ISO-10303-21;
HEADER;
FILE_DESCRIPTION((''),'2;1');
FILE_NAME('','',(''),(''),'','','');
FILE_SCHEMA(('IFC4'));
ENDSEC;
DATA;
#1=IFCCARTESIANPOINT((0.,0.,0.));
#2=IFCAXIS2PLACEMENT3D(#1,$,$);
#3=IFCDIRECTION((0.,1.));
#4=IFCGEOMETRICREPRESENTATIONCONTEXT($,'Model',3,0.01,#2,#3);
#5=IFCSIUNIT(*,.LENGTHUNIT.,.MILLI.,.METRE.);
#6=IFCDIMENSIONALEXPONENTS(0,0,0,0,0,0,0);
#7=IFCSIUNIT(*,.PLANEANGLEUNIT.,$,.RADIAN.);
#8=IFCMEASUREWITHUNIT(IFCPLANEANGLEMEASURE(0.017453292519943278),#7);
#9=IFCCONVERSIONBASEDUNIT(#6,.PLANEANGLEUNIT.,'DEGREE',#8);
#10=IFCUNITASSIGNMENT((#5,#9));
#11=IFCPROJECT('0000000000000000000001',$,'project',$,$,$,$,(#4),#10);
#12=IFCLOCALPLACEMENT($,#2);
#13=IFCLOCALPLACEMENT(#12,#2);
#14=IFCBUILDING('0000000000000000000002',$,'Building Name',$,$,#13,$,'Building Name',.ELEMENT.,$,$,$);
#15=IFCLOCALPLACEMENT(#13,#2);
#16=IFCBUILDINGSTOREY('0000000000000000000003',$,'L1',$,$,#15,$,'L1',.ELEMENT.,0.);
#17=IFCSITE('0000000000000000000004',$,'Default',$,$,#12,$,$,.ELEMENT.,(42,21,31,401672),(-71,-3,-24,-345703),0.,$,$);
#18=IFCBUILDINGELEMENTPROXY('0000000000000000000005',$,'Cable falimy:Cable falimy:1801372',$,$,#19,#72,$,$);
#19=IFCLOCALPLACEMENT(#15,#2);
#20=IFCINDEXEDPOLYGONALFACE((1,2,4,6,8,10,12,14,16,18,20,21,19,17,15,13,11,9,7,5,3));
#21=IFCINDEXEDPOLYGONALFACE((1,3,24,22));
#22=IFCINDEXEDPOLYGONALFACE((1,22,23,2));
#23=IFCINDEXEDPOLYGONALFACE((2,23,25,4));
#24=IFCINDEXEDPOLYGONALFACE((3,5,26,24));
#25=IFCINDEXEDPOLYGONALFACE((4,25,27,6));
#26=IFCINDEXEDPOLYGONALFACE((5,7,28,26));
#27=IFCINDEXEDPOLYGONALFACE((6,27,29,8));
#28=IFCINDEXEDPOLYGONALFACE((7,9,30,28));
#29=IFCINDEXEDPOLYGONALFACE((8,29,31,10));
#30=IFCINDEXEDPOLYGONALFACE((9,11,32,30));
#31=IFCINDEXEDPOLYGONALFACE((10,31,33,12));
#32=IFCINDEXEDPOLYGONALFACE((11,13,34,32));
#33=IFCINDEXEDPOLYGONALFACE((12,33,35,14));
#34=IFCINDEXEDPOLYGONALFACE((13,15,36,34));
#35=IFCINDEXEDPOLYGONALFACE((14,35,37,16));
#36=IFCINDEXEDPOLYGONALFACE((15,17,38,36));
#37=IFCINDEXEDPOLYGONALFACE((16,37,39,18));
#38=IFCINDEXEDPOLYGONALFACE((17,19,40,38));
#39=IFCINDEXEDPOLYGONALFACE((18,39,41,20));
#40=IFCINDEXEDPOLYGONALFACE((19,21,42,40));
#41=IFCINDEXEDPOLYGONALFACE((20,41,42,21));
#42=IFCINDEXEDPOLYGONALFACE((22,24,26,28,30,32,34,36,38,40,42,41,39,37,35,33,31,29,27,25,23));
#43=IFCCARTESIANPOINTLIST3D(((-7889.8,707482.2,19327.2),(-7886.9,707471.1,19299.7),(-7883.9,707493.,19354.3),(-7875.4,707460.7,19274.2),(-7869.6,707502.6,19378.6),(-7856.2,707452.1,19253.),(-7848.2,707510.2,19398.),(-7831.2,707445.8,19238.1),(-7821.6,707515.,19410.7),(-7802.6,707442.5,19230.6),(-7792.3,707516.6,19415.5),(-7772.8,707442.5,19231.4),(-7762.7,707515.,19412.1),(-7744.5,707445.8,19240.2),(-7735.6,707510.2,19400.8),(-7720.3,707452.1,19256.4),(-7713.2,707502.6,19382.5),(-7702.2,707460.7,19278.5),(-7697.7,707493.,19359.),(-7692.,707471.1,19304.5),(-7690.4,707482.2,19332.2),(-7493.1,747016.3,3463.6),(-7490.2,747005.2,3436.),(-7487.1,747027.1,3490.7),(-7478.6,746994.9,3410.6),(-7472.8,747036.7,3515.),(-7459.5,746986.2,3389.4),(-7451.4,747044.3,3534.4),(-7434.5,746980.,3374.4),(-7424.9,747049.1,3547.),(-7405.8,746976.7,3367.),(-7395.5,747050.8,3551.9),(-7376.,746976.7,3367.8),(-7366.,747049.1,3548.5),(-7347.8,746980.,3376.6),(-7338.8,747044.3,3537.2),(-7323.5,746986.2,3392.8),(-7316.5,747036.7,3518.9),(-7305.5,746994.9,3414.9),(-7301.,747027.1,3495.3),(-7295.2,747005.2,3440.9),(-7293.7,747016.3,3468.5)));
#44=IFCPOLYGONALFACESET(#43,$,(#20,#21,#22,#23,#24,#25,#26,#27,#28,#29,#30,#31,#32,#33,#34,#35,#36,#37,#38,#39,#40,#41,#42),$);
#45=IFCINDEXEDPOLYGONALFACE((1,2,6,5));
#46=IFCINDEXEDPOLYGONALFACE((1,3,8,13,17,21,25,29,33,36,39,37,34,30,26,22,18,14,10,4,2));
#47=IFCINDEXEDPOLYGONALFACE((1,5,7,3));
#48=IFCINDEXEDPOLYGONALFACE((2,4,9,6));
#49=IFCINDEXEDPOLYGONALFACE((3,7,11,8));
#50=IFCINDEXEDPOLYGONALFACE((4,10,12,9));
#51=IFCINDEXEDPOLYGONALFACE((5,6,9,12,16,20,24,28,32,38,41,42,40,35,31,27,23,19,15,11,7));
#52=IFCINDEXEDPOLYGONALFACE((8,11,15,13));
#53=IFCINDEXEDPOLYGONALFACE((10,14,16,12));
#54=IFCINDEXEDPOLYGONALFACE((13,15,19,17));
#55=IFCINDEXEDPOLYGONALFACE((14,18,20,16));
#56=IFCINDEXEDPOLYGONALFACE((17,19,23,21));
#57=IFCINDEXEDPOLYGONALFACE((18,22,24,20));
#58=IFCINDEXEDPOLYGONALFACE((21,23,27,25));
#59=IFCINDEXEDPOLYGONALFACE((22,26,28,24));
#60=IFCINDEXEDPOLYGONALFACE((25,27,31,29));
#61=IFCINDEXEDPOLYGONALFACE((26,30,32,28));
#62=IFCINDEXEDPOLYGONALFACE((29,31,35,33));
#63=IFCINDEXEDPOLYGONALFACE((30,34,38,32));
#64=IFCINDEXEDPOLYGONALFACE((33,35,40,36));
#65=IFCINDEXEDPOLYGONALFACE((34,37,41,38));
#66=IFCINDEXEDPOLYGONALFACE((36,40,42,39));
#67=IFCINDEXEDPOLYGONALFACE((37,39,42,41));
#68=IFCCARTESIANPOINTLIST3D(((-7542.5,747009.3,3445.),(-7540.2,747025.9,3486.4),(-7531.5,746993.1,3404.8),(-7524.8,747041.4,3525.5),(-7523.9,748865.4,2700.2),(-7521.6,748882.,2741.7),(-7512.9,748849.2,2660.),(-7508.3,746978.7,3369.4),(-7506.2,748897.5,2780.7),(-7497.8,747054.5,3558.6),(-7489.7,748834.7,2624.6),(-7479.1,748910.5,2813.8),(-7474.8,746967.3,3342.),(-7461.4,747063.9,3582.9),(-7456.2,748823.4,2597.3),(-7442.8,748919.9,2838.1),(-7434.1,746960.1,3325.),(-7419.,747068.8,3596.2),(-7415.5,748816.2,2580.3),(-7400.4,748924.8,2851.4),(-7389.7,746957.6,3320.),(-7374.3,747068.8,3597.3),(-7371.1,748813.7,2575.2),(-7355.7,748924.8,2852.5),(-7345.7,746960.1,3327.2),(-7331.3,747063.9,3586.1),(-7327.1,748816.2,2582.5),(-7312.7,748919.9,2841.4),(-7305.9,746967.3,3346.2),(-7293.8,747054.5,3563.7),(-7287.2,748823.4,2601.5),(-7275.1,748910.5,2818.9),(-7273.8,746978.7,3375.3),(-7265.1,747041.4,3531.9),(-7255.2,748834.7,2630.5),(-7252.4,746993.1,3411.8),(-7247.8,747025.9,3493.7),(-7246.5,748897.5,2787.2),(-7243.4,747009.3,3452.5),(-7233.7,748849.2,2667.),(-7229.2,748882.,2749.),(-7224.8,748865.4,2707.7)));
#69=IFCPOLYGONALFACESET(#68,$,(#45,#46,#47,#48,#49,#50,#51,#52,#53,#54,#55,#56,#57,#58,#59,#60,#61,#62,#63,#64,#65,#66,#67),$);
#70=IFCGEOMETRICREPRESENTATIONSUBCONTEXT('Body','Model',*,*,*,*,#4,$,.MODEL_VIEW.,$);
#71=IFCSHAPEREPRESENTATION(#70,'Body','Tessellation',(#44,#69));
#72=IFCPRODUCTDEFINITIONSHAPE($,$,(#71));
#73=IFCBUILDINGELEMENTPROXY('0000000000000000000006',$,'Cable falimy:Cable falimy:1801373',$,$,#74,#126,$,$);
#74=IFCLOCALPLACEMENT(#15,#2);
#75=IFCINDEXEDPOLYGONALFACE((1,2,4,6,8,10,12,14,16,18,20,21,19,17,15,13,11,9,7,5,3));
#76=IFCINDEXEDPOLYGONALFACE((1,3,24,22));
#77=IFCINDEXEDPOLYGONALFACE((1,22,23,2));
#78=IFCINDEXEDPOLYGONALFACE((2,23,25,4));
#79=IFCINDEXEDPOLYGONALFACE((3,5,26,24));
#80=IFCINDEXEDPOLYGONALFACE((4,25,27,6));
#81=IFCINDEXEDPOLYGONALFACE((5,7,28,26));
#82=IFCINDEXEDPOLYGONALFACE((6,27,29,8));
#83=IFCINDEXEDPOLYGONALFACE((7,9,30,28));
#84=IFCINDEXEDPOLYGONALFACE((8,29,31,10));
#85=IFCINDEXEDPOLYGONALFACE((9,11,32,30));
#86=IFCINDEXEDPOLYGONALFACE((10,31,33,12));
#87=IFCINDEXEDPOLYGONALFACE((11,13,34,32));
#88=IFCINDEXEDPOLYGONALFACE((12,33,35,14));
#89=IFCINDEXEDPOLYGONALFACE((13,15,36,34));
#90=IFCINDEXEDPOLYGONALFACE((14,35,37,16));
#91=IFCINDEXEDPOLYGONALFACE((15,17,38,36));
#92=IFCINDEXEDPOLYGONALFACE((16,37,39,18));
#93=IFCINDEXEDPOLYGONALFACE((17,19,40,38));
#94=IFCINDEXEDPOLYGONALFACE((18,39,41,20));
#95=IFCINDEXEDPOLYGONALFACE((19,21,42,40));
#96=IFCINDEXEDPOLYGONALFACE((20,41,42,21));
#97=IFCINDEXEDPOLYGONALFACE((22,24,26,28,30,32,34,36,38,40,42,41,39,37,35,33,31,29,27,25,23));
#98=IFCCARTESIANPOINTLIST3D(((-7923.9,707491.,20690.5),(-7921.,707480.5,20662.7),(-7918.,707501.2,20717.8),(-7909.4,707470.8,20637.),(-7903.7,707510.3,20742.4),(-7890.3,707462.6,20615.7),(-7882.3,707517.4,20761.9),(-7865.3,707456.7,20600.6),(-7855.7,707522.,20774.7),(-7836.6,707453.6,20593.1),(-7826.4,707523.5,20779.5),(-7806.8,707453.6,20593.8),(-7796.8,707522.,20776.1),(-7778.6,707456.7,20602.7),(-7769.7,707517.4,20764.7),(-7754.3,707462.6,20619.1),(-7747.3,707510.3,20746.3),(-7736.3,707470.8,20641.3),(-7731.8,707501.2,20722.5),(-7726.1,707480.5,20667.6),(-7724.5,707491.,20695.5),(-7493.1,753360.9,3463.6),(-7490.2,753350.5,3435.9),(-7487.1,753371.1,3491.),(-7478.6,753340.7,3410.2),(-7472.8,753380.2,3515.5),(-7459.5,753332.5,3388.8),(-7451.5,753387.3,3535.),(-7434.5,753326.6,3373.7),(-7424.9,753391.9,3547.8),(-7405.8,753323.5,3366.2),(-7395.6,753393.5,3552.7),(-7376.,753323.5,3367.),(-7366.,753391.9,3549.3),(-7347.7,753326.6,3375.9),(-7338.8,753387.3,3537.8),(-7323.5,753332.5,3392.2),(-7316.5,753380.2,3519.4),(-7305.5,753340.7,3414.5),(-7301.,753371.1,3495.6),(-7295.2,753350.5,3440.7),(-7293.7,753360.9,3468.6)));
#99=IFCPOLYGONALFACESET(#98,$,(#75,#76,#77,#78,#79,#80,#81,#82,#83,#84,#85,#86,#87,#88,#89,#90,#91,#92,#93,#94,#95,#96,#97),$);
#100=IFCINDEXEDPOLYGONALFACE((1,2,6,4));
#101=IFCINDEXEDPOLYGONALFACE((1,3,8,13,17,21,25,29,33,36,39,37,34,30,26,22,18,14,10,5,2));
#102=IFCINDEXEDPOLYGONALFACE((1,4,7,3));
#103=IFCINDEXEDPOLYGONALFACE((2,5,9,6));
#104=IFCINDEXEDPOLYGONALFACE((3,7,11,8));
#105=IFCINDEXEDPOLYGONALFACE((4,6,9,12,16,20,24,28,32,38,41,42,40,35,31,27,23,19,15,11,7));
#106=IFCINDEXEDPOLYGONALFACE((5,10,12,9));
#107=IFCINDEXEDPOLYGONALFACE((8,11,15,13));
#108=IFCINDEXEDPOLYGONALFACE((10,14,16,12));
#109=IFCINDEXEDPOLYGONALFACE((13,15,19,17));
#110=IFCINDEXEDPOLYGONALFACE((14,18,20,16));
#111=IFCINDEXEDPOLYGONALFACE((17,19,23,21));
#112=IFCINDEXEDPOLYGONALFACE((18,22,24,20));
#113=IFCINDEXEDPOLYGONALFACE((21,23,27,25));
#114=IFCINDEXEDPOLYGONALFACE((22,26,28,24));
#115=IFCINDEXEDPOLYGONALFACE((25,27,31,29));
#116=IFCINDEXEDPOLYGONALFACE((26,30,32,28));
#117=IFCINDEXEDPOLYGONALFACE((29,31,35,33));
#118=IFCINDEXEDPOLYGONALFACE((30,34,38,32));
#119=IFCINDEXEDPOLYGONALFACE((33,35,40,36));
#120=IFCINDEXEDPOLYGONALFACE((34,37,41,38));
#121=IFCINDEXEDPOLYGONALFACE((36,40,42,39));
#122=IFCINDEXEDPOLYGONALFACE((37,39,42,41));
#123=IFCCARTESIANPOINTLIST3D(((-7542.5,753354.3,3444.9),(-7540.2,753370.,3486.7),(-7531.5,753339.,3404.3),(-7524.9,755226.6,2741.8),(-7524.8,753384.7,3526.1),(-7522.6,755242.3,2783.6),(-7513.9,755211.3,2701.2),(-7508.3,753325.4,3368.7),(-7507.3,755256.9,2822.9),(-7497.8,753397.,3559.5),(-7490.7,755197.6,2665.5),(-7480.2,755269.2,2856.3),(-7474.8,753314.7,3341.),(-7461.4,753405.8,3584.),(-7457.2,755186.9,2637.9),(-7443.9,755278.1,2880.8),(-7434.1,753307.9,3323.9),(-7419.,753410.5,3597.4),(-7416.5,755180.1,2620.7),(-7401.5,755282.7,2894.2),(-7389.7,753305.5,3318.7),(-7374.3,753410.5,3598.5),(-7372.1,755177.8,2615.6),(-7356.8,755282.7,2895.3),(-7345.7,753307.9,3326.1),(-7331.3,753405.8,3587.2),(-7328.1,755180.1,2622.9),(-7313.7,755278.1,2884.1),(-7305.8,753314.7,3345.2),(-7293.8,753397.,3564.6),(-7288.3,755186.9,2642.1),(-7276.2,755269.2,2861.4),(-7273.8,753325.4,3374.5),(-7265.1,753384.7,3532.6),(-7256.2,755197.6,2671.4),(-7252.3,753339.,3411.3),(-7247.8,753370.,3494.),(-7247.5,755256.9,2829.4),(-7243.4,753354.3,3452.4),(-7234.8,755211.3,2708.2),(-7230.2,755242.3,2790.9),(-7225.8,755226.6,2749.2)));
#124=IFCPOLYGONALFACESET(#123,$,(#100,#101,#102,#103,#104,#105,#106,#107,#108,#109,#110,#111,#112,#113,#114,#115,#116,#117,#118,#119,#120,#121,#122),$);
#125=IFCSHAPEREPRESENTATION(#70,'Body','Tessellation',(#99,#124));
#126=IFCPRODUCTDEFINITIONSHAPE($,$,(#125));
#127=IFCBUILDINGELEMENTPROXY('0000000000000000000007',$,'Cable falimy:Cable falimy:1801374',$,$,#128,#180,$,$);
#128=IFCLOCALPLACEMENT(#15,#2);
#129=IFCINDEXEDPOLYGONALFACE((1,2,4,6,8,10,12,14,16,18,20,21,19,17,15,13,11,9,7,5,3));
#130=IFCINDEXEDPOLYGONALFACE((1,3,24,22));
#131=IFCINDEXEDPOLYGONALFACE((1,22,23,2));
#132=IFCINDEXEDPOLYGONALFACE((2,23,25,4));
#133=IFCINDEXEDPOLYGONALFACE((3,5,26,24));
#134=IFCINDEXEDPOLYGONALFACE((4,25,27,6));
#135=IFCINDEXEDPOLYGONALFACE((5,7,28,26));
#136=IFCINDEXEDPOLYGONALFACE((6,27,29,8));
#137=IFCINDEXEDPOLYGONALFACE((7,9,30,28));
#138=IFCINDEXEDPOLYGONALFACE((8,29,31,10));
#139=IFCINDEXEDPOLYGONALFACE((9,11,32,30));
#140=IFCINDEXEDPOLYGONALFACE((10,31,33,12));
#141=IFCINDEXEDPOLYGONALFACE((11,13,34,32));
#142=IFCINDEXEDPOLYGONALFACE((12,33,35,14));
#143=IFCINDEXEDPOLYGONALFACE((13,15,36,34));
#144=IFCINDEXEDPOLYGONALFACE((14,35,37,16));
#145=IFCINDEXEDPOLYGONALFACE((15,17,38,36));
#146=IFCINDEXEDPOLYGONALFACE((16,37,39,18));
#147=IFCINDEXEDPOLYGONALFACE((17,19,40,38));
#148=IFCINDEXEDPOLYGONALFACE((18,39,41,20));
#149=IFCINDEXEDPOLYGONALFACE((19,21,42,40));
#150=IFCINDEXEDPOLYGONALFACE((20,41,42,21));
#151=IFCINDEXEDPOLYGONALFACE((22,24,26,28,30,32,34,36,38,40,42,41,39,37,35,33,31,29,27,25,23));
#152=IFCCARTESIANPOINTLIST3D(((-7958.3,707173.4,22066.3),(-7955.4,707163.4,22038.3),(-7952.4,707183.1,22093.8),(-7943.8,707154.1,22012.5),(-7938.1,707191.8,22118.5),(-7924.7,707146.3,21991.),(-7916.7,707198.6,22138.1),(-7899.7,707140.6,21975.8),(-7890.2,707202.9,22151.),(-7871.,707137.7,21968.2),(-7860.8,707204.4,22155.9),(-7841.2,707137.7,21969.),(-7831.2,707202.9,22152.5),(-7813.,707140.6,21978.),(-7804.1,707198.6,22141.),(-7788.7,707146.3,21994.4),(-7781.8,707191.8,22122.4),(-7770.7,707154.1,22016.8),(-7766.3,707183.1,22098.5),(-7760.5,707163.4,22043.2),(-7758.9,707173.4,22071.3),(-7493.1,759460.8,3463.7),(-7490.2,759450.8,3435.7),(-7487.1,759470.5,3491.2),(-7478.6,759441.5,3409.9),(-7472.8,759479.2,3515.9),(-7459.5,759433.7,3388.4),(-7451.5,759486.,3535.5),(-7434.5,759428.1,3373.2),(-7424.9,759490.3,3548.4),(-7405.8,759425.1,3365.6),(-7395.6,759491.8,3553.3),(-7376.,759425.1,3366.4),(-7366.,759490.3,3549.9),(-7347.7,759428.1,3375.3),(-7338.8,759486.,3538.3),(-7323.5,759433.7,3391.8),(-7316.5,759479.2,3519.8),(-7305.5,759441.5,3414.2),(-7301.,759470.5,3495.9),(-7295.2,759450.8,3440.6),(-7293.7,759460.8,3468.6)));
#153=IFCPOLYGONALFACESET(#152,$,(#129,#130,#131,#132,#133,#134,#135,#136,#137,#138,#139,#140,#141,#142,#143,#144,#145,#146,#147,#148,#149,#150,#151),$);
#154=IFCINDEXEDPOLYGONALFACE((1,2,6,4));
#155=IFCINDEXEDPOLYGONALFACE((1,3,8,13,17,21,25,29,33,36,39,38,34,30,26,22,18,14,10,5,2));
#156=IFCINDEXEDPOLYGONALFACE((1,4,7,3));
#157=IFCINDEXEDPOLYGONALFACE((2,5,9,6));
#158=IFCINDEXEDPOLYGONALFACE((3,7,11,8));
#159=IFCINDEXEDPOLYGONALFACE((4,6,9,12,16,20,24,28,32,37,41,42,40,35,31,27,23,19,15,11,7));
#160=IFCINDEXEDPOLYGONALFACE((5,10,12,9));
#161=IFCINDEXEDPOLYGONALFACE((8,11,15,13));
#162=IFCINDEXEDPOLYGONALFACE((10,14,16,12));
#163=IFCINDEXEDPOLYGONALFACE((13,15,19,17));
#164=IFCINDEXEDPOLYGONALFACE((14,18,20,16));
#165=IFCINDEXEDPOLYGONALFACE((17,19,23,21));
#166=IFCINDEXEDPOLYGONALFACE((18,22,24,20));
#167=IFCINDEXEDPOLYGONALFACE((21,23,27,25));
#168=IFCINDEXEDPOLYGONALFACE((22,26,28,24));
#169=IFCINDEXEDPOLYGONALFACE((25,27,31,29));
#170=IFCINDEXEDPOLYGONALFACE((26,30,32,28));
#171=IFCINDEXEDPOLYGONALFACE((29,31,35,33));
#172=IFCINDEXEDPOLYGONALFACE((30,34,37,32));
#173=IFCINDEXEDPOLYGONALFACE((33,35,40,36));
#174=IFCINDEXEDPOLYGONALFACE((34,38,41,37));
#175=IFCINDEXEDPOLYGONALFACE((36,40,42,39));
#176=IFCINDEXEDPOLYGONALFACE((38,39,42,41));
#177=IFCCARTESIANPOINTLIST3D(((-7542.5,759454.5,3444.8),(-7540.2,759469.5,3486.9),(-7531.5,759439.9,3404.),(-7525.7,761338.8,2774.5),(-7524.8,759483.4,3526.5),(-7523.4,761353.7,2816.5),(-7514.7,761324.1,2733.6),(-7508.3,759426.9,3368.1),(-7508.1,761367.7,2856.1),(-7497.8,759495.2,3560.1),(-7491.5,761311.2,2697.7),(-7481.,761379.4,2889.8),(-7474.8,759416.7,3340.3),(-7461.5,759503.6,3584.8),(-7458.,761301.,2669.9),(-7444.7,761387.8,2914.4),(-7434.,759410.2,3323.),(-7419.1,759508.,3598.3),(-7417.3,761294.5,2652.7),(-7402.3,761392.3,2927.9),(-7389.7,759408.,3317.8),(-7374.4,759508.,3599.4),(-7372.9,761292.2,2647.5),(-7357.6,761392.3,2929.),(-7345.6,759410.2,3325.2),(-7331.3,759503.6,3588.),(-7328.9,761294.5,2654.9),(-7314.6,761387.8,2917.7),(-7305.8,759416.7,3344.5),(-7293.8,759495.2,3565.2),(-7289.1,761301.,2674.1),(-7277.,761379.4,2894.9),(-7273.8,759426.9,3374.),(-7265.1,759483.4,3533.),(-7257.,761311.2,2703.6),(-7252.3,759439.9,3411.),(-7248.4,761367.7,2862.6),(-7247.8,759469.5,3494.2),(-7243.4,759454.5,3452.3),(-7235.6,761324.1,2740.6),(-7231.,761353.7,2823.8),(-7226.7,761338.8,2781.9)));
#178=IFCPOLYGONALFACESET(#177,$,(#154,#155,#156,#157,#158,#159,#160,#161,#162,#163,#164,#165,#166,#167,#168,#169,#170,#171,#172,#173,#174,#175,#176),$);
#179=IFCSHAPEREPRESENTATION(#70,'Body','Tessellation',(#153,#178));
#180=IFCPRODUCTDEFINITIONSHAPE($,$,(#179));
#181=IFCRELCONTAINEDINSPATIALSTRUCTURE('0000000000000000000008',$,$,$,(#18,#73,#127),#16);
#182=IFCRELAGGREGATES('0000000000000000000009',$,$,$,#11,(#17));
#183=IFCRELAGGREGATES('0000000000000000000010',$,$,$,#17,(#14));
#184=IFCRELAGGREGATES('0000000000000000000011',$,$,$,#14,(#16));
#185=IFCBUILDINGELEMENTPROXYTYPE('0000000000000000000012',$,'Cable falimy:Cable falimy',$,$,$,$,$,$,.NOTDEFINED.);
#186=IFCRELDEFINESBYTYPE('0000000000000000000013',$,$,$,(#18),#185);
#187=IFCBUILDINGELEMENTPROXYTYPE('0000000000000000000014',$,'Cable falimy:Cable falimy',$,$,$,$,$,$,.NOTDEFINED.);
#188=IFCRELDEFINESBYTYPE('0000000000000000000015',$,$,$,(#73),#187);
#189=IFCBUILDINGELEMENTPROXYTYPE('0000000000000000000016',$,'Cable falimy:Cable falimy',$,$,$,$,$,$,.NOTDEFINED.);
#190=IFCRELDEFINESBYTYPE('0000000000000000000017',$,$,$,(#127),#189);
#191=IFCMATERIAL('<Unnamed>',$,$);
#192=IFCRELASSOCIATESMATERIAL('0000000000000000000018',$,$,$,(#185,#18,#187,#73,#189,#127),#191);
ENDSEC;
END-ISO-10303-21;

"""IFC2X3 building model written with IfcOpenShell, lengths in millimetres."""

from ifc_helpers import new_model, entity, si_unit, converted_unit, direction, frame, frame_2d, origin, place, context, subcontext, project, spatial, circle, extrude, source, transform, mapped, material, type_object, type_shapes, element, save


model = new_model("IFC2X3")

# Units and contexts
model_context = context("Model", 3, precision=0.01, world=origin(), true_north=direction((0.0, 1.0)))
body_context = subcontext(model_context, "Body", "Model", "MODEL_VIEW")
ifc_project = project(units=[si_unit("LENGTHUNIT", "METRE", prefix="MILLI"), converted_unit("PLANEANGLEUNIT", "DEGREE", entity("IfcPlaneAngleMeasure", 0.017453292519943278), si_unit("PLANEANGLEUNIT", "RADIAN"), dimensions=[0, 0, 0, 0, 0, 0, 0])], contexts=[model_context])

# Site, building, storey
site_placement = place(None, origin())
site = spatial("IfcSite", under=ifc_project, at=site_placement, Name="Default", CompositionType="ELEMENT", RefLatitude=(42, 21, 31, 401672), RefLongitude=(-71, -3, -24, -345703), RefElevation=0.0)
building_placement = place(site_placement, origin())
building = spatial("IfcBuilding", under=site, at=building_placement, Name="Building Name", LongName="Building Name", CompositionType="ELEMENT")
storey_placement = place(building_placement, origin())
storey = spatial("IfcBuildingStorey", under=building, at=storey_placement, Name="L1", LongName="L1", CompositionType="ELEMENT", Elevation=0.0)

# Shared definitions
ifc_material = material(Name="<Unnamed>")

# Building element proxies
building_element_proxy_type_1 = type_object("IfcBuildingElementProxyType", Name="Cable falimy:Cable falimy", PredefinedType="NOTDEFINED", material=ifc_material)
shared_shape_1 = source(origin(), body_context, "Body", "SweptSolid", [
    extrude(circle(Radius=100.0, at=frame_2d((0.0, 0.0), x_axis=(1.0, 0.0))), frame((0.0, 0.0, 0.0), z_axis=(0.928031, 0.0, 0.372502), x_axis=(-0.372502, 0.0, 0.928031)), (0.0, 0.0, 1.0), 42600.0),
    extrude(circle(Radius=150.0, at=frame_2d((0.0, 0.0), x_axis=(1.0, 0.0))), frame((-1856.1, 0.0, -745.0), z_axis=(0.928031, 0.0, 0.372502), x_axis=(0.372502, 0.0, -0.928031)), (0.0, 0.0, 1.0), 2000.0),
])
type_shapes(building_element_proxy_type_1, [shared_shape_1])
proxy_1_placement = place(storey_placement, frame((-7393.2, 747013.5, 3459.1), z_axis=(-0.025001, 0.0, 0.999687), x_axis=(0.0, -1.0, 0.0)))
element("IfcBuildingElementProxy", 1, at=proxy_1_placement, inside=storey, type_object=building_element_proxy_type_1, material=ifc_material, Name="Cable falimy:Cable falimy:1801372", context=body_context, shape_type="MappedRepresentation", body=[
    mapped(shared_shape_1, transform((0.0, 0.0, 0.0), scale=1.0)),
])
building_element_proxy_type_2 = type_object("IfcBuildingElementProxyType", Name="Cable falimy:Cable falimy", PredefinedType="NOTDEFINED", material=ifc_material)
shared_shape_2 = source(origin(), body_context, "Body", "SweptSolid", [
    extrude(circle(Radius=100.0, at=frame_2d((0.0, 0.0), x_axis=(1.0, 0.0))), frame((0.0, 0.0, 0.0), z_axis=(0.936121, 0.0, 0.351678), x_axis=(-0.351678, 0.0, 0.936121)), (0.0, 0.0, 1.0), 49000.0),
    extrude(circle(Radius=150.0, at=frame_2d((0.0, 0.0), x_axis=(1.0, 0.0))), frame((-1872.2, 0.0, -703.4), z_axis=(0.936121, 0.0, 0.351678), x_axis=(0.351678, 0.0, -0.936121)), (0.0, 0.0, 1.0), 2000.0),
])
type_shapes(building_element_proxy_type_2, [shared_shape_2])
proxy_2_placement = place(storey_placement, frame((-7393.2, 753358.3, 3459.1), z_axis=(-0.025001, 0.0, 0.999687), x_axis=(0.0, -1.0, 0.0)))
element("IfcBuildingElementProxy", 2, at=proxy_2_placement, inside=storey, type_object=building_element_proxy_type_2, material=ifc_material, Name="Cable falimy:Cable falimy:1801373", context=body_context, shape_type="MappedRepresentation", body=[
    mapped(shared_shape_2, transform((0.0, 0.0, 0.0), scale=1.0)),
])
building_element_proxy_type_3 = type_object("IfcBuildingElementProxyType", Name="Cable falimy:Cable falimy", PredefinedType="NOTDEFINED", material=ifc_material)
shared_shape_3 = source(origin(), body_context, "Body", "SweptSolid", [
    extrude(circle(Radius=100.0, at=frame_2d((0.0, 0.0), x_axis=(1.0, 0.0))), frame((0.0, 0.0, 0.0), z_axis=(0.942116, 0.0, 0.335287), x_axis=(-0.335287, 0.0, 0.942116)), (0.0, 0.0, 1.0), 55500.0),
    extrude(circle(Radius=150.0, at=frame_2d((0.0, 0.0), x_axis=(1.0, 0.0))), frame((-1884.2, 0.0, -670.6), z_axis=(0.942116, 0.0, 0.335287), x_axis=(0.335287, 0.0, -0.942116)), (0.0, 0.0, 1.0), 2000.0),
])
type_shapes(building_element_proxy_type_3, [shared_shape_3])
proxy_3_placement = place(storey_placement, frame((-7393.2, 759458.3, 3459.1), z_axis=(-0.025001, 0.0, 0.999687), x_axis=(0.0, -1.0, 0.0)))
element("IfcBuildingElementProxy", 3, at=proxy_3_placement, inside=storey, type_object=building_element_proxy_type_3, material=ifc_material, Name="Cable falimy:Cable falimy:1801374", context=body_context, shape_type="MappedRepresentation", body=[
    mapped(shared_shape_3, transform((0.0, 0.0, 0.0), scale=1.0)),
])

save(model, "model.ifc")
